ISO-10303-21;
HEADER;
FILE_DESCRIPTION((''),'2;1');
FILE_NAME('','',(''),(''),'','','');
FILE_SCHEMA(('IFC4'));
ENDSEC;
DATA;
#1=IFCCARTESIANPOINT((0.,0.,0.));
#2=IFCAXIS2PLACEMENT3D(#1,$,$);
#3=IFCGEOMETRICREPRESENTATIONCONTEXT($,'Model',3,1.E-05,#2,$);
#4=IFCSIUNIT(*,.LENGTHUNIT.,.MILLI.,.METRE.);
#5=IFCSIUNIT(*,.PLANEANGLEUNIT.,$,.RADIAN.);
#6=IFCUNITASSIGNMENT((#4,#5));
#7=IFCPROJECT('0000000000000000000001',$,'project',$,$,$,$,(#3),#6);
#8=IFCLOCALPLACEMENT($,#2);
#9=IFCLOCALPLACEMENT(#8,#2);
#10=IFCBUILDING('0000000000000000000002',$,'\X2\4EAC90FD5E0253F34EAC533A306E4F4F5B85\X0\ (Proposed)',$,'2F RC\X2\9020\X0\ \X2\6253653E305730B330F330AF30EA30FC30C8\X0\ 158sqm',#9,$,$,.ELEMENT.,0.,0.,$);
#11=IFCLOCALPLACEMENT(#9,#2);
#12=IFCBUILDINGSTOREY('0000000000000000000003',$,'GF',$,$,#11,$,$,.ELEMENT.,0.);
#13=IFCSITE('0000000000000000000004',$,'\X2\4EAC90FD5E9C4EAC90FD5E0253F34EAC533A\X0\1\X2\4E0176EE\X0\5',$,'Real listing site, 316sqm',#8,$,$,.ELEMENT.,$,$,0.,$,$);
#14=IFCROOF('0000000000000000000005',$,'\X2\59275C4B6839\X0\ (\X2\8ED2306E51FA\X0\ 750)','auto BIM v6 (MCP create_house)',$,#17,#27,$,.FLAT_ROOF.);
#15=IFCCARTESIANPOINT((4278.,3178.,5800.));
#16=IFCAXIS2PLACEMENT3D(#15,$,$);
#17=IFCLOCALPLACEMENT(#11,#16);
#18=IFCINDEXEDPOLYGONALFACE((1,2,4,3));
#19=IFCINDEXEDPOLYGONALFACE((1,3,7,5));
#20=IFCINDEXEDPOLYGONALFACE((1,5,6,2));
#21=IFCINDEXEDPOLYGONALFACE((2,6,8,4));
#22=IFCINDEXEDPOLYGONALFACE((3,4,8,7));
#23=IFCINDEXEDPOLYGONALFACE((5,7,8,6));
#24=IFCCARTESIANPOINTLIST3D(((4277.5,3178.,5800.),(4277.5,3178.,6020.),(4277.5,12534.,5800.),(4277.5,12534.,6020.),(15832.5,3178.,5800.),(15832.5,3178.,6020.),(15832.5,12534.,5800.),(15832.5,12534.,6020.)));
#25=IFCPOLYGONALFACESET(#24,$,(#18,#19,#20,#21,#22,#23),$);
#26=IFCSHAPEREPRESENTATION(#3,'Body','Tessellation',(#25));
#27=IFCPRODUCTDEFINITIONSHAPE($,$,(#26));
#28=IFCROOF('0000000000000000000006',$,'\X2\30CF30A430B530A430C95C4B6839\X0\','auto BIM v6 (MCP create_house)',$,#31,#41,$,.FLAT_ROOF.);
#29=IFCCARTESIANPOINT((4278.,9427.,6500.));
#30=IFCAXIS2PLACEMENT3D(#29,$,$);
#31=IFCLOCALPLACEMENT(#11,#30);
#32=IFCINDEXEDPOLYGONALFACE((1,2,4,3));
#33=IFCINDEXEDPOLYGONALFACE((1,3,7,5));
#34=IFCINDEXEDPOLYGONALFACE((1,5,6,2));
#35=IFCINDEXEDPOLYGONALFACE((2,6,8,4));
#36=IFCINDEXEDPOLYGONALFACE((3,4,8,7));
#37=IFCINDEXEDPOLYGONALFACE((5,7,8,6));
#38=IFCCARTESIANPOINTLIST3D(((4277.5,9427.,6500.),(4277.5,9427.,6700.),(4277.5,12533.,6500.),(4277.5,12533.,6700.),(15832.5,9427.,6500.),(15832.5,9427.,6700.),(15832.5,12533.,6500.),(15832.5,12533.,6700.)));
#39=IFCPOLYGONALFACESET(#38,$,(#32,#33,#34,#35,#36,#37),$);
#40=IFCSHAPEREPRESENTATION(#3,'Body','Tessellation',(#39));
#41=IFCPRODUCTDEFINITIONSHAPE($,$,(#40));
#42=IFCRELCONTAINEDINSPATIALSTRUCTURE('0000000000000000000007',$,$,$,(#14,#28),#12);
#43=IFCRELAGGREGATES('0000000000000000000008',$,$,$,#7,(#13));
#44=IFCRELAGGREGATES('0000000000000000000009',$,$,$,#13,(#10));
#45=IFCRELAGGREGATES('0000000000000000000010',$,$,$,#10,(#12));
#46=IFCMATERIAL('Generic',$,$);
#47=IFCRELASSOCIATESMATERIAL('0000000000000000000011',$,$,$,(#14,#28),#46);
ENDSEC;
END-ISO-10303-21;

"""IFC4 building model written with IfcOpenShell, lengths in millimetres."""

from ifc_helpers import new_model, si_unit, frame, frame_2d, origin, place, context, project, spatial, rectangle, extrude, material, element, save


model = new_model("IFC4")

# Units and contexts
model_context = context("Model", 3, precision=1e-05, world=origin())
ifc_project = project(units=[si_unit("LENGTHUNIT", "METRE", prefix="MILLI"), si_unit("PLANEANGLEUNIT", "RADIAN")], contexts=[model_context])

# Site, building, storey
site_placement = place(None, origin())
site = spatial("IfcSite", under=ifc_project, at=site_placement, Name="京都府京都市右京区1丁目5", ObjectType="Real listing site, 316sqm", CompositionType="ELEMENT", RefElevation=0.0)
building_placement = place(site_placement, origin())
building = spatial("IfcBuilding", under=site, at=building_placement, Name="京都市右京区の住宅 (Proposed)", ObjectType="2F RC造 打放しコンクリート 158sqm", CompositionType="ELEMENT", ElevationOfRefHeight=0.0, ElevationOfTerrain=0.0)
storey_placement = place(building_placement, origin())
storey = spatial("IfcBuildingStorey", under=building, at=storey_placement, Name="GF", CompositionType="ELEMENT", Elevation=0.0)

# Shared definitions
ifc_material = material(Name="Generic")

# Roofs
roof_1_placement = place(storey_placement, frame((4278.0, 3178.0, 5800.0)))
element("IfcRoof", 1, at=roof_1_placement, inside=storey, material=ifc_material, Name="大屋根 (軒の出 750)", Description="auto BIM v6 (MCP create_house)", PredefinedType="FLAT_ROOF", context=model_context, shape_type="SweptSolid", body=[
    extrude(rectangle(XDim=11555.0, YDim=9356.0, at=frame_2d((5777.0, 4678.0))), frame((4278.0, 3178.0, 5800.0)), (0.0, 0.0, 1.0), 220.0),
])
roof_2_placement = place(storey_placement, frame((4278.0, 9427.0, 6500.0)))
element("IfcRoof", 2, at=roof_2_placement, inside=storey, material=ifc_material, Name="ハイサイド屋根", Description="auto BIM v6 (MCP create_house)", PredefinedType="FLAT_ROOF", context=model_context, shape_type="SweptSolid", body=[
    extrude(rectangle(XDim=11555.0, YDim=3106.0, at=frame_2d((5777.0, 1553.0))), frame((4278.0, 9427.0, 6500.0)), (0.0, 0.0, 1.0), 200.0),
])

save(model, "model.ifc")
